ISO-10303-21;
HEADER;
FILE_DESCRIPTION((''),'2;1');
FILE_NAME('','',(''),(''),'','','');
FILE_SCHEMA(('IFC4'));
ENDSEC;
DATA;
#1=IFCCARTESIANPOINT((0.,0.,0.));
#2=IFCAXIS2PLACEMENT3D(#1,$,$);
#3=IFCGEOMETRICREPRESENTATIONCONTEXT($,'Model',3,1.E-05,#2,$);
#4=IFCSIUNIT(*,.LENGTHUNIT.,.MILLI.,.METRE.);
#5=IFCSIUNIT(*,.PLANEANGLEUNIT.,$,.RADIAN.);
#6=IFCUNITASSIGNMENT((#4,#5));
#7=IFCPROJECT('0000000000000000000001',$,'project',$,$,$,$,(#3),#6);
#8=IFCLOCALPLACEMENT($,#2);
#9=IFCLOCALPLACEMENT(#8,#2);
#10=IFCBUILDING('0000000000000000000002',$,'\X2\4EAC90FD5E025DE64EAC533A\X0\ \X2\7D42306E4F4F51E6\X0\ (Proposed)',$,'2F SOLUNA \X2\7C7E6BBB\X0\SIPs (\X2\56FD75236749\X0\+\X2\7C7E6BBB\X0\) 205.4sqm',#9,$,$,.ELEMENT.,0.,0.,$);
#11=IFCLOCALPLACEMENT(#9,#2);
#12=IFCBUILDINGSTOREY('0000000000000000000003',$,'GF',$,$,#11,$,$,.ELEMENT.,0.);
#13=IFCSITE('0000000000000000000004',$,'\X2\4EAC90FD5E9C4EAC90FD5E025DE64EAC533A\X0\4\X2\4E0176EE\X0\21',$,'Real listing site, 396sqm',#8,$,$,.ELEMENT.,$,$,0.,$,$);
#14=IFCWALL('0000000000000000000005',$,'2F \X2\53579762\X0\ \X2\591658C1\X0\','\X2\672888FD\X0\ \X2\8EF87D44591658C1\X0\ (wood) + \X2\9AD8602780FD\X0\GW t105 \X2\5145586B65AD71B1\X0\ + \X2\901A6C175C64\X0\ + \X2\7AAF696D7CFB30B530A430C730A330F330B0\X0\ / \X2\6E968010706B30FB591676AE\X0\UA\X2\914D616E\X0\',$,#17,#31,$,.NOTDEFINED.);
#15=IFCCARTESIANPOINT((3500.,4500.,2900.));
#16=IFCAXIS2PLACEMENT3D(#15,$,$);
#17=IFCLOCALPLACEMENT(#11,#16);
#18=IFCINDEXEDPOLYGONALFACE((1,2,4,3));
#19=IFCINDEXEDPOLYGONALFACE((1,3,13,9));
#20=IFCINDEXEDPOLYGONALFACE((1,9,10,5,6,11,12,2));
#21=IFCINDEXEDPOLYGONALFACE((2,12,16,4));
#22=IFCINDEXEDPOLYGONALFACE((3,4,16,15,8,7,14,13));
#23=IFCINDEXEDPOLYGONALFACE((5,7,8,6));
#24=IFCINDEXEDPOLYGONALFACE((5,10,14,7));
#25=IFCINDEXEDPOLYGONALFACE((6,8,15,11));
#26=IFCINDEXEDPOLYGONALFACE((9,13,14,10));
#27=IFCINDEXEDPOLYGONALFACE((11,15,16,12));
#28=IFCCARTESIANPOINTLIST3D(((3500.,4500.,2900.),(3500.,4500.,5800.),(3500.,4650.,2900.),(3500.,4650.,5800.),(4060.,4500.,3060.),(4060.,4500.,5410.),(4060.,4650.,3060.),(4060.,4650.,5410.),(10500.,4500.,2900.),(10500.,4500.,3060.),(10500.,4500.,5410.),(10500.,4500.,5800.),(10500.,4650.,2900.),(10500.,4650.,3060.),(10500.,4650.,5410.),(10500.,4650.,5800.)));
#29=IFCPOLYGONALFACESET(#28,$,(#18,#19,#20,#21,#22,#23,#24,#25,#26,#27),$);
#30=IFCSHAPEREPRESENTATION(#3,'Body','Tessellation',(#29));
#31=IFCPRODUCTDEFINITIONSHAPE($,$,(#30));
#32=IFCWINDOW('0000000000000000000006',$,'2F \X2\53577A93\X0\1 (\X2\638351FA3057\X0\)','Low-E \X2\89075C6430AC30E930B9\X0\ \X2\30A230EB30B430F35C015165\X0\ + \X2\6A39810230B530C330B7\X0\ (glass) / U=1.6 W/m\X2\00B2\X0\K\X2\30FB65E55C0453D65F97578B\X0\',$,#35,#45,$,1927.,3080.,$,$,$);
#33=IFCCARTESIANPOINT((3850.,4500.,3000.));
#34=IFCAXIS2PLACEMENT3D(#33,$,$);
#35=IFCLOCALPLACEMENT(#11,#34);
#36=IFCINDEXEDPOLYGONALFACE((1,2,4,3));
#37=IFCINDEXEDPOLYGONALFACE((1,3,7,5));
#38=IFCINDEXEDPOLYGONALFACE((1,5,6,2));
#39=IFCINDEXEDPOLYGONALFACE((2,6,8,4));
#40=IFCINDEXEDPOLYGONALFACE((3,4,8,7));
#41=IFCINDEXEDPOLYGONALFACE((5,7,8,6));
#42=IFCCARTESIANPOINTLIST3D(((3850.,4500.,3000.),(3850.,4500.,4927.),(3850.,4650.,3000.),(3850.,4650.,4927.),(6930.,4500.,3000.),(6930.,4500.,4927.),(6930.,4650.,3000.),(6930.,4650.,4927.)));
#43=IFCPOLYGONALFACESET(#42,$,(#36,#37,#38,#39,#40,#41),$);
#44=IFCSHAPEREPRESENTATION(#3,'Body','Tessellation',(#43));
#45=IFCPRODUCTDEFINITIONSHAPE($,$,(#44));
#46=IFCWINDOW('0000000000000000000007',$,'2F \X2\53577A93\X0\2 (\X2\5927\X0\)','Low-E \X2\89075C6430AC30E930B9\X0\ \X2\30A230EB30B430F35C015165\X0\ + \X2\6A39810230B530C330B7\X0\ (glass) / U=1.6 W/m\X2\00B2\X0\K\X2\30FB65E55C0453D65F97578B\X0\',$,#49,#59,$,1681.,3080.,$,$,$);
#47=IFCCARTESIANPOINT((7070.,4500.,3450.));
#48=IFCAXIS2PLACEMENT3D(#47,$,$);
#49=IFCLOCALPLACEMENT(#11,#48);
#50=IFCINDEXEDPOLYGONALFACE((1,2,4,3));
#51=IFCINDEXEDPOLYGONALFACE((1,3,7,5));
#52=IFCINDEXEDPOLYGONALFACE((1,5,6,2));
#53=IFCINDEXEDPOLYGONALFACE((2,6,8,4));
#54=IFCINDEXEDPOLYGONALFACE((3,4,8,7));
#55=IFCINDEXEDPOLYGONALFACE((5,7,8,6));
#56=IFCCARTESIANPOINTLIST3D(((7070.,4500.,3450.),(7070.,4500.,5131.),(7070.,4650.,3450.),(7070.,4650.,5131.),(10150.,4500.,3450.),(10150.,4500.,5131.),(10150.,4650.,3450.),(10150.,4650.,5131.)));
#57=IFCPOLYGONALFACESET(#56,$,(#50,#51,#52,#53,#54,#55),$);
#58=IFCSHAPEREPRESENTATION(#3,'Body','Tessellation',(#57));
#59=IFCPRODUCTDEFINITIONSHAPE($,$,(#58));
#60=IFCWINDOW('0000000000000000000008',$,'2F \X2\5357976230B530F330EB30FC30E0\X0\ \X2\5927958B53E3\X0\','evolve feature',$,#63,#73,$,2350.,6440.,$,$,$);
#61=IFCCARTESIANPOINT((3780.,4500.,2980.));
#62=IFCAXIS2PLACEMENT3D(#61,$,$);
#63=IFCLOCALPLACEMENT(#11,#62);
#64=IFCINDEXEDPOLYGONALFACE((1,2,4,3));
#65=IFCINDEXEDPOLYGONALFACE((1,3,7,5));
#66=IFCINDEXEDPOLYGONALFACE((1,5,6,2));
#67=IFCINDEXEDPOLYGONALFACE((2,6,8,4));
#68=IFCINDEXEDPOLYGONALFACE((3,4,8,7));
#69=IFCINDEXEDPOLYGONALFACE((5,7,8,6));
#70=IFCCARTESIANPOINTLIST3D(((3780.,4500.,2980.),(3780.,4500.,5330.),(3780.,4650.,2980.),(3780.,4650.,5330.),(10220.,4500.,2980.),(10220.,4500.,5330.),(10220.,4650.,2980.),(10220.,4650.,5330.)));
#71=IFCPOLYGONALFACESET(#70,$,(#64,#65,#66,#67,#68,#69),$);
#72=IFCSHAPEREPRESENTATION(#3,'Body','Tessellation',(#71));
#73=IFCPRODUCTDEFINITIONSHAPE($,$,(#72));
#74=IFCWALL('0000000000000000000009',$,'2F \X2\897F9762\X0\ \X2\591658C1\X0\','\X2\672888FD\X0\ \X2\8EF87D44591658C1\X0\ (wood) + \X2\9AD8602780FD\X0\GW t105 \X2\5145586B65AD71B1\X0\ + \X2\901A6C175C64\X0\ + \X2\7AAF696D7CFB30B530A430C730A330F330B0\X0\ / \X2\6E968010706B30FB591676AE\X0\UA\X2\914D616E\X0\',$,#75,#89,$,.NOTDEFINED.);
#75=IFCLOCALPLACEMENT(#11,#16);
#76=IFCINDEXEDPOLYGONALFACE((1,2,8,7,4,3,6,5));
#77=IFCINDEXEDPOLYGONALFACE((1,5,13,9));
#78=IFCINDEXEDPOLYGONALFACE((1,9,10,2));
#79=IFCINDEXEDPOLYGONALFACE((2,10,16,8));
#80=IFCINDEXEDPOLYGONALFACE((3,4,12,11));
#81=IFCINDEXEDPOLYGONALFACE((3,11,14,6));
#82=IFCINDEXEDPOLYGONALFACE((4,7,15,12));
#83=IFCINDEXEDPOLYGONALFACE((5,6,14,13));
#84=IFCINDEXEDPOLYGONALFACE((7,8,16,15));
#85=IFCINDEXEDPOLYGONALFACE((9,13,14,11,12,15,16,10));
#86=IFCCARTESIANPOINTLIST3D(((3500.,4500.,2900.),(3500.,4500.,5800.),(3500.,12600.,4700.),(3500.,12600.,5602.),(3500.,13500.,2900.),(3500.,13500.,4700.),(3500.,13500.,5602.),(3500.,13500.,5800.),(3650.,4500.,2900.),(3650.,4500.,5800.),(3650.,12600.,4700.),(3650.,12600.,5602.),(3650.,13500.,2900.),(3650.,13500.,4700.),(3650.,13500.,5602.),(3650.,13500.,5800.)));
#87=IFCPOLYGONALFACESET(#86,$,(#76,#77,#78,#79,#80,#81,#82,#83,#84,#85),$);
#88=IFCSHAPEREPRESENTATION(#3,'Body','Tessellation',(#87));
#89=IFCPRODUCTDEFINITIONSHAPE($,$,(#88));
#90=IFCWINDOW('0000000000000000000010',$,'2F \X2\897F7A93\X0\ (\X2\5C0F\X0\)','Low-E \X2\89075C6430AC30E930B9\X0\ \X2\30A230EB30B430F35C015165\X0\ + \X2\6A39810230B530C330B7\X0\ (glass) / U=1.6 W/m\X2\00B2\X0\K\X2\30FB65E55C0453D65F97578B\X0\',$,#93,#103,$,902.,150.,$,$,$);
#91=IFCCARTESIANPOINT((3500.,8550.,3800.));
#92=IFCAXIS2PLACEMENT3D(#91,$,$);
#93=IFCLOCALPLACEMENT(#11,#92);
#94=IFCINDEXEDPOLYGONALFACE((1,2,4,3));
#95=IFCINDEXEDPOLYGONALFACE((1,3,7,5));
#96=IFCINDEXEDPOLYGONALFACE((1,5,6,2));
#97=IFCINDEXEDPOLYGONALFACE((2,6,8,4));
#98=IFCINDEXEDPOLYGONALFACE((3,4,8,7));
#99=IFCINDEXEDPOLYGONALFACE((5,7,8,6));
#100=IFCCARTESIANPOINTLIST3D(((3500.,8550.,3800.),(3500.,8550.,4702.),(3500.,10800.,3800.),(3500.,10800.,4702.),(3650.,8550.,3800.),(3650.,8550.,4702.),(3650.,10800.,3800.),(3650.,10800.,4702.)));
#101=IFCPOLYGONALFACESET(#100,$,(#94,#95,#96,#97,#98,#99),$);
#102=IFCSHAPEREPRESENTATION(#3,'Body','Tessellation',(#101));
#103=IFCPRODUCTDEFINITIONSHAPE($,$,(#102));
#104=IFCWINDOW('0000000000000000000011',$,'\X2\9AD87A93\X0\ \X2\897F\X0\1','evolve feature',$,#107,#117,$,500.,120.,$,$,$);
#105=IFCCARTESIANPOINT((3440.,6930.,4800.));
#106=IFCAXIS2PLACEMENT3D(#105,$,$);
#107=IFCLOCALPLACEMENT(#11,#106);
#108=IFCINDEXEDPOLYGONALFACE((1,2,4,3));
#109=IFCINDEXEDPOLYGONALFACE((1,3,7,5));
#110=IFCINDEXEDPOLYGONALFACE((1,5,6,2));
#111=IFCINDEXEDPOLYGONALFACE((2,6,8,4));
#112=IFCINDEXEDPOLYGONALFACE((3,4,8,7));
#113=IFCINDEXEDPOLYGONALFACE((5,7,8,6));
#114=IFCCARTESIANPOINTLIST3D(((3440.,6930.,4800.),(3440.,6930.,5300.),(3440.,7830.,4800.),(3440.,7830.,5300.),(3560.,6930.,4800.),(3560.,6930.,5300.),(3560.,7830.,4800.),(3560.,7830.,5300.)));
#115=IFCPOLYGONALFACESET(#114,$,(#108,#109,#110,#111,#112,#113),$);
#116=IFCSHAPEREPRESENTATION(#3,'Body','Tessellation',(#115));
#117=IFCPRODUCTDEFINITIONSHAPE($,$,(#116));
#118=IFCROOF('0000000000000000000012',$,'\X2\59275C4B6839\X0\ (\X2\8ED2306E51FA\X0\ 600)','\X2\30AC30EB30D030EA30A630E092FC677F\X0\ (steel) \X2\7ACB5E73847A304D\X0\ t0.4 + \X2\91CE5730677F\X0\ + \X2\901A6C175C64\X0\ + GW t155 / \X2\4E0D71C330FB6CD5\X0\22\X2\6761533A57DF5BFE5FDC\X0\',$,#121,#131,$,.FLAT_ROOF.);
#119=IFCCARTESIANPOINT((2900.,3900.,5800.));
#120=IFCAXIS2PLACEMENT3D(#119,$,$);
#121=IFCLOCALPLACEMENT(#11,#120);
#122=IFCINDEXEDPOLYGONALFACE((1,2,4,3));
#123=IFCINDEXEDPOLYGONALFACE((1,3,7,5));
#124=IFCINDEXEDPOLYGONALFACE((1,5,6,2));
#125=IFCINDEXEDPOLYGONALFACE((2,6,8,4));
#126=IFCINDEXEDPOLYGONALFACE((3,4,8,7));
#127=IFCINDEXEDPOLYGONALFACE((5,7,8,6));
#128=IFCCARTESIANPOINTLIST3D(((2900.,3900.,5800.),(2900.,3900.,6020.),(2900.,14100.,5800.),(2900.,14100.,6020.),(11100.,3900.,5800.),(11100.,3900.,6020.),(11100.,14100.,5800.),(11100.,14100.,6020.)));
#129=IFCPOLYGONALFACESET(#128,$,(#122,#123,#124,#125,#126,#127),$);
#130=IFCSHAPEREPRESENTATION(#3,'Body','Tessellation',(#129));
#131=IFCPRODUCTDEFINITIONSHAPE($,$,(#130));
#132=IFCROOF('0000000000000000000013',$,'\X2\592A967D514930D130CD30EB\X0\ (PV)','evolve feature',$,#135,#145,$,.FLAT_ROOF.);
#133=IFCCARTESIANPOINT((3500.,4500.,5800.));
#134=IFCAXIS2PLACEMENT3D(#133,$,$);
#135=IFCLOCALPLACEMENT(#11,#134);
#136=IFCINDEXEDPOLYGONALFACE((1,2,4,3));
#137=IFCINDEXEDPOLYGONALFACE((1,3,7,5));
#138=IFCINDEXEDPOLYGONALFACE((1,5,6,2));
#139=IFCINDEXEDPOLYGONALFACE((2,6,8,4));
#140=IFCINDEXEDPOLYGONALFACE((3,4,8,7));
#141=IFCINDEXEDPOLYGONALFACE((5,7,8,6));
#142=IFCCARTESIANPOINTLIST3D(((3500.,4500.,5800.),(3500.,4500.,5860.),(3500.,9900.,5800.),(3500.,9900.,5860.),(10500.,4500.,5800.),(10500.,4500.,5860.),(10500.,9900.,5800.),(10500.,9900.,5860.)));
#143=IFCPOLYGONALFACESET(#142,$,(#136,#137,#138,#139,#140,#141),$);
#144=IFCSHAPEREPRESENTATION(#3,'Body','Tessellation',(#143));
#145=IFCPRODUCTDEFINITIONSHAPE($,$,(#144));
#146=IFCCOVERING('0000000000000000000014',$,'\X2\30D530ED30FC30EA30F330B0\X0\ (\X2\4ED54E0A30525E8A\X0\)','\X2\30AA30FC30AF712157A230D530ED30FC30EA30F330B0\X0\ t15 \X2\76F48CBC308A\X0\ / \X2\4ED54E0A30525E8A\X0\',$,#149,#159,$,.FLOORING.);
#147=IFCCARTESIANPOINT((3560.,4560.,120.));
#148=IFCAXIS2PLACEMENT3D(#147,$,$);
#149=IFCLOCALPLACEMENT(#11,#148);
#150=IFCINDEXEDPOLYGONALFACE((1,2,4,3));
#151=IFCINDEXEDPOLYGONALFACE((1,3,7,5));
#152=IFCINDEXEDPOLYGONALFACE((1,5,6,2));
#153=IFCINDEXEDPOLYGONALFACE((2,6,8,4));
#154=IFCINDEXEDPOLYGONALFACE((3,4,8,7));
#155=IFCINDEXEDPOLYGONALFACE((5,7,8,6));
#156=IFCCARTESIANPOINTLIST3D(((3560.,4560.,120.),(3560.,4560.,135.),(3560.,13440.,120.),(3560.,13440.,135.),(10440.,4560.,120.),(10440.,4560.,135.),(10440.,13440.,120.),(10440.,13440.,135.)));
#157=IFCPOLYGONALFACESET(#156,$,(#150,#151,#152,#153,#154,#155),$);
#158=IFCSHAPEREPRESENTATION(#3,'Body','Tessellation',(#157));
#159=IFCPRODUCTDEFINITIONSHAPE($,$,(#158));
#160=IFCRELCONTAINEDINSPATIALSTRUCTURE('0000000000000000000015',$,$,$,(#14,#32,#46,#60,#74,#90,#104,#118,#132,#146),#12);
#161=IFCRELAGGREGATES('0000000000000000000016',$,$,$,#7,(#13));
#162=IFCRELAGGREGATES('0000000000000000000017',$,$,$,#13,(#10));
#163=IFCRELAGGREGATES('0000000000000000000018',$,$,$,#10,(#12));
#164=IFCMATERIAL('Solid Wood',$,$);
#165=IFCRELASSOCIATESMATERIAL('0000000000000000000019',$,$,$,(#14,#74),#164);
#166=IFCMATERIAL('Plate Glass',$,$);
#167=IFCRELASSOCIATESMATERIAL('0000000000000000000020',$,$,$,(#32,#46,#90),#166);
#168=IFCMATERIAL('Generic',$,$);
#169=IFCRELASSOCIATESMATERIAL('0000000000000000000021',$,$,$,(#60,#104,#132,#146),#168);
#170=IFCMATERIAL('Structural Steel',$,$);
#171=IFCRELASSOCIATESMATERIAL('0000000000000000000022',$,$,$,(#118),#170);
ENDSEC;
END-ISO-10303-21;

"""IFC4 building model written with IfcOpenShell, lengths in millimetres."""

from ifc_helpers import new_model, si_unit, frame, frame_2d, origin, place, context, project, spatial, rectangle, extrude, material, element, fill, save


model = new_model("IFC4")

# Units and contexts
model_context = context("Model", 3, precision=1e-05, world=origin())
ifc_project = project(units=[si_unit("LENGTHUNIT", "METRE", prefix="MILLI"), si_unit("PLANEANGLEUNIT", "RADIAN")], contexts=[model_context])

# Site, building, storey
site_placement = place(None, origin())
site = spatial("IfcSite", under=ifc_project, at=site_placement, Name="京都府京都市左京区4丁目21", ObjectType="Real listing site, 396sqm", CompositionType="ELEMENT", RefElevation=0.0)
building_placement = place(site_placement, origin())
building = spatial("IfcBuilding", under=site, at=building_placement, Name="京都市左京区 終の住処 (Proposed)", ObjectType="2F SOLUNA 籾殻SIPs (国産杉+籾殻) 205.4sqm", CompositionType="ELEMENT", ElevationOfRefHeight=0.0, ElevationOfTerrain=0.0)
storey_placement = place(building_placement, origin())
storey = spatial("IfcBuildingStorey", under=building, at=storey_placement, Name="GF", CompositionType="ELEMENT", Elevation=0.0)

# Shared definitions
ifc_material_1 = material(Name="Solid Wood")

# Shared definitions
ifc_material_2 = material(Name="Plate Glass")
ifc_material_3 = material(Name="Generic")

# Walls, openings, windows
wall_1_placement = place(storey_placement, frame((3500.0, 4500.0, 2900.0)))
wall_1 = element("IfcWall", 1, at=wall_1_placement, inside=storey, material=ifc_material_1, Name="2F 南面 外壁", Description="木製 軸組外壁 (wood) + 高性能GW t105 充填断熱 + 通気層 + 窯業系サイディング / 準耐火・外皮UA配慮", PredefinedType="NOTDEFINED", context=model_context, shape_type="SweptSolid", body=[
    extrude(rectangle(XDim=7000.0, YDim=150.0, at=frame_2d((3500.0, 75.0))), frame((3500.0, 4500.0, 2900.0)), (0.0, 0.0, 1.0), 2900.0),
])
opening_1_placement = place(storey_placement, frame((3850.0, 4500.0, 3000.0)))
opening_1 = element("IfcOpeningElement", 2, at=opening_1_placement, cuts=wall_1, PredefinedType="NOTDEFINED", context=model_context, shape_type="SweptSolid", body=[
    extrude(rectangle(XDim=3080.0, YDim=150.0, at=frame_2d((1540.0, 75.0))), frame((3850.0, 4500.0, 3000.0)), (0.0, 0.0, 1.0), 1927.0),
])
opening_2_placement = place(storey_placement, frame((7070.0, 4500.0, 3450.0)))
opening_2 = element("IfcOpeningElement", 3, at=opening_2_placement, cuts=wall_1, PredefinedType="NOTDEFINED", context=model_context, shape_type="SweptSolid", body=[
    extrude(rectangle(XDim=3080.0, YDim=150.0, at=frame_2d((1540.0, 75.0))), frame((7070.0, 4500.0, 3450.0)), (0.0, 0.0, 1.0), 1681.0),
])
opening_3_placement = place(storey_placement, frame((3780.0, 4500.0, 2980.0)))
opening_3 = element("IfcOpeningElement", 4, at=opening_3_placement, cuts=wall_1, PredefinedType="NOTDEFINED", context=model_context, shape_type="SweptSolid", body=[
    extrude(rectangle(XDim=6440.0, YDim=150.0, at=frame_2d((3220.0, 75.0))), frame((3780.0, 4500.0, 2980.0)), (0.0, 0.0, 1.0), 2350.0),
])
window_1_placement = place(storey_placement, frame((3850.0, 4500.0, 3000.0)))
window_1 = element("IfcWindow", 5, at=window_1_placement, inside=storey, material=ifc_material_2, Name="2F 南窓1 (掃出し)", Description="Low-E 複層ガラス アルゴン封入 + 樹脂サッシ (glass) / U=1.6 W/m²K・日射取得型", OverallHeight=1927.0, OverallWidth=3080.0, context=model_context, shape_type="SweptSolid", body=[
    extrude(rectangle(XDim=3080.0, YDim=150.0, at=frame_2d((1540.0, 75.0))), frame((3850.0, 4500.0, 3000.0)), (0.0, 0.0, 1.0), 1927.0),
])
fill(opening_1, window_1)
window_2_placement = place(storey_placement, frame((7070.0, 4500.0, 3450.0)))
window_2 = element("IfcWindow", 6, at=window_2_placement, inside=storey, material=ifc_material_2, Name="2F 南窓2 (大)", Description="Low-E 複層ガラス アルゴン封入 + 樹脂サッシ (glass) / U=1.6 W/m²K・日射取得型", OverallHeight=1681.0, OverallWidth=3080.0, context=model_context, shape_type="SweptSolid", body=[
    extrude(rectangle(XDim=3080.0, YDim=150.0, at=frame_2d((1540.0, 75.0))), frame((7070.0, 4500.0, 3450.0)), (0.0, 0.0, 1.0), 1681.0),
])
fill(opening_2, window_2)
window_3_placement = place(storey_placement, frame((3780.0, 4500.0, 2980.0)))
window_3 = element("IfcWindow", 7, at=window_3_placement, inside=storey, material=ifc_material_3, Name="2F 南面サンルーム 大開口", Description="evolve feature", OverallHeight=2350.0, OverallWidth=6440.0, context=model_context, shape_type="SweptSolid", body=[
    extrude(rectangle(XDim=6440.0, YDim=150.0, at=frame_2d((3220.0, 75.0))), frame((3780.0, 4500.0, 2980.0)), (0.0, 0.0, 1.0), 2350.0),
])
fill(opening_3, window_3)
wall_2_placement = place(storey_placement, frame((3500.0, 4500.0, 2900.0)))
wall_2 = element("IfcWall", 8, at=wall_2_placement, inside=storey, material=ifc_material_1, Name="2F 西面 外壁", Description="木製 軸組外壁 (wood) + 高性能GW t105 充填断熱 + 通気層 + 窯業系サイディング / 準耐火・外皮UA配慮", PredefinedType="NOTDEFINED", context=model_context, shape_type="SweptSolid", body=[
    extrude(rectangle(XDim=150.0, YDim=9000.0, at=frame_2d((75.0, 4500.0))), frame((3500.0, 4500.0, 2900.0)), (0.0, 0.0, 1.0), 2900.0),
])
opening_4_placement = place(storey_placement, frame((3500.0, 8550.0, 3800.0)))
opening_4 = element("IfcOpeningElement", 9, at=opening_4_placement, cuts=wall_2, PredefinedType="NOTDEFINED", context=model_context, shape_type="SweptSolid", body=[
    extrude(rectangle(XDim=150.0, YDim=2250.0, at=frame_2d((75.0, 1125.0))), frame((3500.0, 8550.0, 3800.0)), (0.0, 0.0, 1.0), 902.0),
])
opening_5_placement = place(storey_placement, frame((3440.0, 6930.0, 4800.0)))
opening_5 = element("IfcOpeningElement", 10, at=opening_5_placement, cuts=wall_2, PredefinedType="NOTDEFINED", context=model_context, shape_type="SweptSolid", body=[
    extrude(rectangle(XDim=120.0, YDim=900.0, at=frame_2d((60.0, 450.0))), frame((3440.0, 6930.0, 4800.0)), (0.0, 0.0, 1.0), 500.0),
])
window_4_placement = place(storey_placement, frame((3500.0, 8550.0, 3800.0)))
window_4 = element("IfcWindow", 11, at=window_4_placement, inside=storey, material=ifc_material_2, Name="2F 西窓 (小)", Description="Low-E 複層ガラス アルゴン封入 + 樹脂サッシ (glass) / U=1.6 W/m²K・日射取得型", OverallHeight=902.0, OverallWidth=150.0, context=model_context, shape_type="SweptSolid", body=[
    extrude(rectangle(XDim=150.0, YDim=2250.0, at=frame_2d((75.0, 1125.0))), frame((3500.0, 8550.0, 3800.0)), (0.0, 0.0, 1.0), 902.0),
])
fill(opening_4, window_4)
window_5_placement = place(storey_placement, frame((3440.0, 6930.0, 4800.0)))
window_5 = element("IfcWindow", 12, at=window_5_placement, inside=storey, material=ifc_material_3, Name="高窓 西1", Description="evolve feature", OverallHeight=500.0, OverallWidth=120.0, context=model_context, shape_type="SweptSolid", body=[
    extrude(rectangle(XDim=120.0, YDim=900.0, at=frame_2d((60.0, 450.0))), frame((3440.0, 6930.0, 4800.0)), (0.0, 0.0, 1.0), 500.0),
])
fill(opening_5, window_5)

# Roofs
ifc_material_4 = material(Name="Structural Steel")
roof_1_placement = place(storey_placement, frame((2900.0, 3900.0, 5800.0)))
element("IfcRoof", 13, at=roof_1_placement, inside=storey, material=ifc_material_4, Name="大屋根 (軒の出 600)", Description="ガルバリウム鋼板 (steel) 立平葺き t0.4 + 野地板 + 通気層 + GW t155 / 不燃・法22条区域対応", PredefinedType="FLAT_ROOF", context=model_context, shape_type="SweptSolid", body=[
    extrude(rectangle(XDim=8200.0, YDim=10200.0, at=frame_2d((4100.0, 5100.0))), frame((2900.0, 3900.0, 5800.0)), (0.0, 0.0, 1.0), 220.0),
])
roof_2_placement = place(storey_placement, frame((3500.0, 4500.0, 5800.0)))
element("IfcRoof", 14, at=roof_2_placement, inside=storey, material=ifc_material_3, Name="太陽光パネル (PV)", Description="evolve feature", PredefinedType="FLAT_ROOF", context=model_context, shape_type="SweptSolid", body=[
    extrude(rectangle(XDim=7000.0, YDim=5400.0, at=frame_2d((3500.0, 2700.0))), frame((3500.0, 4500.0, 5800.0)), (0.0, 0.0, 1.0), 60.0),
])

# Covering
covering_placement = place(storey_placement, frame((3560.0, 4560.0, 120.0)))
element("IfcCovering", 15, at=covering_placement, inside=storey, material=ifc_material_3, Name="フローリング (仕上げ床)", Description="オーク無垢フローリング t15 直貼り / 仕上げ床", PredefinedType="FLOORING", context=model_context, shape_type="SweptSolid", body=[
    extrude(rectangle(XDim=6880.0, YDim=8880.0, at=frame_2d((3440.0, 4440.0))), frame((3560.0, 4560.0, 120.0)), (0.0, 0.0, 1.0), 15.0),
])

save(model, "model.ifc")
